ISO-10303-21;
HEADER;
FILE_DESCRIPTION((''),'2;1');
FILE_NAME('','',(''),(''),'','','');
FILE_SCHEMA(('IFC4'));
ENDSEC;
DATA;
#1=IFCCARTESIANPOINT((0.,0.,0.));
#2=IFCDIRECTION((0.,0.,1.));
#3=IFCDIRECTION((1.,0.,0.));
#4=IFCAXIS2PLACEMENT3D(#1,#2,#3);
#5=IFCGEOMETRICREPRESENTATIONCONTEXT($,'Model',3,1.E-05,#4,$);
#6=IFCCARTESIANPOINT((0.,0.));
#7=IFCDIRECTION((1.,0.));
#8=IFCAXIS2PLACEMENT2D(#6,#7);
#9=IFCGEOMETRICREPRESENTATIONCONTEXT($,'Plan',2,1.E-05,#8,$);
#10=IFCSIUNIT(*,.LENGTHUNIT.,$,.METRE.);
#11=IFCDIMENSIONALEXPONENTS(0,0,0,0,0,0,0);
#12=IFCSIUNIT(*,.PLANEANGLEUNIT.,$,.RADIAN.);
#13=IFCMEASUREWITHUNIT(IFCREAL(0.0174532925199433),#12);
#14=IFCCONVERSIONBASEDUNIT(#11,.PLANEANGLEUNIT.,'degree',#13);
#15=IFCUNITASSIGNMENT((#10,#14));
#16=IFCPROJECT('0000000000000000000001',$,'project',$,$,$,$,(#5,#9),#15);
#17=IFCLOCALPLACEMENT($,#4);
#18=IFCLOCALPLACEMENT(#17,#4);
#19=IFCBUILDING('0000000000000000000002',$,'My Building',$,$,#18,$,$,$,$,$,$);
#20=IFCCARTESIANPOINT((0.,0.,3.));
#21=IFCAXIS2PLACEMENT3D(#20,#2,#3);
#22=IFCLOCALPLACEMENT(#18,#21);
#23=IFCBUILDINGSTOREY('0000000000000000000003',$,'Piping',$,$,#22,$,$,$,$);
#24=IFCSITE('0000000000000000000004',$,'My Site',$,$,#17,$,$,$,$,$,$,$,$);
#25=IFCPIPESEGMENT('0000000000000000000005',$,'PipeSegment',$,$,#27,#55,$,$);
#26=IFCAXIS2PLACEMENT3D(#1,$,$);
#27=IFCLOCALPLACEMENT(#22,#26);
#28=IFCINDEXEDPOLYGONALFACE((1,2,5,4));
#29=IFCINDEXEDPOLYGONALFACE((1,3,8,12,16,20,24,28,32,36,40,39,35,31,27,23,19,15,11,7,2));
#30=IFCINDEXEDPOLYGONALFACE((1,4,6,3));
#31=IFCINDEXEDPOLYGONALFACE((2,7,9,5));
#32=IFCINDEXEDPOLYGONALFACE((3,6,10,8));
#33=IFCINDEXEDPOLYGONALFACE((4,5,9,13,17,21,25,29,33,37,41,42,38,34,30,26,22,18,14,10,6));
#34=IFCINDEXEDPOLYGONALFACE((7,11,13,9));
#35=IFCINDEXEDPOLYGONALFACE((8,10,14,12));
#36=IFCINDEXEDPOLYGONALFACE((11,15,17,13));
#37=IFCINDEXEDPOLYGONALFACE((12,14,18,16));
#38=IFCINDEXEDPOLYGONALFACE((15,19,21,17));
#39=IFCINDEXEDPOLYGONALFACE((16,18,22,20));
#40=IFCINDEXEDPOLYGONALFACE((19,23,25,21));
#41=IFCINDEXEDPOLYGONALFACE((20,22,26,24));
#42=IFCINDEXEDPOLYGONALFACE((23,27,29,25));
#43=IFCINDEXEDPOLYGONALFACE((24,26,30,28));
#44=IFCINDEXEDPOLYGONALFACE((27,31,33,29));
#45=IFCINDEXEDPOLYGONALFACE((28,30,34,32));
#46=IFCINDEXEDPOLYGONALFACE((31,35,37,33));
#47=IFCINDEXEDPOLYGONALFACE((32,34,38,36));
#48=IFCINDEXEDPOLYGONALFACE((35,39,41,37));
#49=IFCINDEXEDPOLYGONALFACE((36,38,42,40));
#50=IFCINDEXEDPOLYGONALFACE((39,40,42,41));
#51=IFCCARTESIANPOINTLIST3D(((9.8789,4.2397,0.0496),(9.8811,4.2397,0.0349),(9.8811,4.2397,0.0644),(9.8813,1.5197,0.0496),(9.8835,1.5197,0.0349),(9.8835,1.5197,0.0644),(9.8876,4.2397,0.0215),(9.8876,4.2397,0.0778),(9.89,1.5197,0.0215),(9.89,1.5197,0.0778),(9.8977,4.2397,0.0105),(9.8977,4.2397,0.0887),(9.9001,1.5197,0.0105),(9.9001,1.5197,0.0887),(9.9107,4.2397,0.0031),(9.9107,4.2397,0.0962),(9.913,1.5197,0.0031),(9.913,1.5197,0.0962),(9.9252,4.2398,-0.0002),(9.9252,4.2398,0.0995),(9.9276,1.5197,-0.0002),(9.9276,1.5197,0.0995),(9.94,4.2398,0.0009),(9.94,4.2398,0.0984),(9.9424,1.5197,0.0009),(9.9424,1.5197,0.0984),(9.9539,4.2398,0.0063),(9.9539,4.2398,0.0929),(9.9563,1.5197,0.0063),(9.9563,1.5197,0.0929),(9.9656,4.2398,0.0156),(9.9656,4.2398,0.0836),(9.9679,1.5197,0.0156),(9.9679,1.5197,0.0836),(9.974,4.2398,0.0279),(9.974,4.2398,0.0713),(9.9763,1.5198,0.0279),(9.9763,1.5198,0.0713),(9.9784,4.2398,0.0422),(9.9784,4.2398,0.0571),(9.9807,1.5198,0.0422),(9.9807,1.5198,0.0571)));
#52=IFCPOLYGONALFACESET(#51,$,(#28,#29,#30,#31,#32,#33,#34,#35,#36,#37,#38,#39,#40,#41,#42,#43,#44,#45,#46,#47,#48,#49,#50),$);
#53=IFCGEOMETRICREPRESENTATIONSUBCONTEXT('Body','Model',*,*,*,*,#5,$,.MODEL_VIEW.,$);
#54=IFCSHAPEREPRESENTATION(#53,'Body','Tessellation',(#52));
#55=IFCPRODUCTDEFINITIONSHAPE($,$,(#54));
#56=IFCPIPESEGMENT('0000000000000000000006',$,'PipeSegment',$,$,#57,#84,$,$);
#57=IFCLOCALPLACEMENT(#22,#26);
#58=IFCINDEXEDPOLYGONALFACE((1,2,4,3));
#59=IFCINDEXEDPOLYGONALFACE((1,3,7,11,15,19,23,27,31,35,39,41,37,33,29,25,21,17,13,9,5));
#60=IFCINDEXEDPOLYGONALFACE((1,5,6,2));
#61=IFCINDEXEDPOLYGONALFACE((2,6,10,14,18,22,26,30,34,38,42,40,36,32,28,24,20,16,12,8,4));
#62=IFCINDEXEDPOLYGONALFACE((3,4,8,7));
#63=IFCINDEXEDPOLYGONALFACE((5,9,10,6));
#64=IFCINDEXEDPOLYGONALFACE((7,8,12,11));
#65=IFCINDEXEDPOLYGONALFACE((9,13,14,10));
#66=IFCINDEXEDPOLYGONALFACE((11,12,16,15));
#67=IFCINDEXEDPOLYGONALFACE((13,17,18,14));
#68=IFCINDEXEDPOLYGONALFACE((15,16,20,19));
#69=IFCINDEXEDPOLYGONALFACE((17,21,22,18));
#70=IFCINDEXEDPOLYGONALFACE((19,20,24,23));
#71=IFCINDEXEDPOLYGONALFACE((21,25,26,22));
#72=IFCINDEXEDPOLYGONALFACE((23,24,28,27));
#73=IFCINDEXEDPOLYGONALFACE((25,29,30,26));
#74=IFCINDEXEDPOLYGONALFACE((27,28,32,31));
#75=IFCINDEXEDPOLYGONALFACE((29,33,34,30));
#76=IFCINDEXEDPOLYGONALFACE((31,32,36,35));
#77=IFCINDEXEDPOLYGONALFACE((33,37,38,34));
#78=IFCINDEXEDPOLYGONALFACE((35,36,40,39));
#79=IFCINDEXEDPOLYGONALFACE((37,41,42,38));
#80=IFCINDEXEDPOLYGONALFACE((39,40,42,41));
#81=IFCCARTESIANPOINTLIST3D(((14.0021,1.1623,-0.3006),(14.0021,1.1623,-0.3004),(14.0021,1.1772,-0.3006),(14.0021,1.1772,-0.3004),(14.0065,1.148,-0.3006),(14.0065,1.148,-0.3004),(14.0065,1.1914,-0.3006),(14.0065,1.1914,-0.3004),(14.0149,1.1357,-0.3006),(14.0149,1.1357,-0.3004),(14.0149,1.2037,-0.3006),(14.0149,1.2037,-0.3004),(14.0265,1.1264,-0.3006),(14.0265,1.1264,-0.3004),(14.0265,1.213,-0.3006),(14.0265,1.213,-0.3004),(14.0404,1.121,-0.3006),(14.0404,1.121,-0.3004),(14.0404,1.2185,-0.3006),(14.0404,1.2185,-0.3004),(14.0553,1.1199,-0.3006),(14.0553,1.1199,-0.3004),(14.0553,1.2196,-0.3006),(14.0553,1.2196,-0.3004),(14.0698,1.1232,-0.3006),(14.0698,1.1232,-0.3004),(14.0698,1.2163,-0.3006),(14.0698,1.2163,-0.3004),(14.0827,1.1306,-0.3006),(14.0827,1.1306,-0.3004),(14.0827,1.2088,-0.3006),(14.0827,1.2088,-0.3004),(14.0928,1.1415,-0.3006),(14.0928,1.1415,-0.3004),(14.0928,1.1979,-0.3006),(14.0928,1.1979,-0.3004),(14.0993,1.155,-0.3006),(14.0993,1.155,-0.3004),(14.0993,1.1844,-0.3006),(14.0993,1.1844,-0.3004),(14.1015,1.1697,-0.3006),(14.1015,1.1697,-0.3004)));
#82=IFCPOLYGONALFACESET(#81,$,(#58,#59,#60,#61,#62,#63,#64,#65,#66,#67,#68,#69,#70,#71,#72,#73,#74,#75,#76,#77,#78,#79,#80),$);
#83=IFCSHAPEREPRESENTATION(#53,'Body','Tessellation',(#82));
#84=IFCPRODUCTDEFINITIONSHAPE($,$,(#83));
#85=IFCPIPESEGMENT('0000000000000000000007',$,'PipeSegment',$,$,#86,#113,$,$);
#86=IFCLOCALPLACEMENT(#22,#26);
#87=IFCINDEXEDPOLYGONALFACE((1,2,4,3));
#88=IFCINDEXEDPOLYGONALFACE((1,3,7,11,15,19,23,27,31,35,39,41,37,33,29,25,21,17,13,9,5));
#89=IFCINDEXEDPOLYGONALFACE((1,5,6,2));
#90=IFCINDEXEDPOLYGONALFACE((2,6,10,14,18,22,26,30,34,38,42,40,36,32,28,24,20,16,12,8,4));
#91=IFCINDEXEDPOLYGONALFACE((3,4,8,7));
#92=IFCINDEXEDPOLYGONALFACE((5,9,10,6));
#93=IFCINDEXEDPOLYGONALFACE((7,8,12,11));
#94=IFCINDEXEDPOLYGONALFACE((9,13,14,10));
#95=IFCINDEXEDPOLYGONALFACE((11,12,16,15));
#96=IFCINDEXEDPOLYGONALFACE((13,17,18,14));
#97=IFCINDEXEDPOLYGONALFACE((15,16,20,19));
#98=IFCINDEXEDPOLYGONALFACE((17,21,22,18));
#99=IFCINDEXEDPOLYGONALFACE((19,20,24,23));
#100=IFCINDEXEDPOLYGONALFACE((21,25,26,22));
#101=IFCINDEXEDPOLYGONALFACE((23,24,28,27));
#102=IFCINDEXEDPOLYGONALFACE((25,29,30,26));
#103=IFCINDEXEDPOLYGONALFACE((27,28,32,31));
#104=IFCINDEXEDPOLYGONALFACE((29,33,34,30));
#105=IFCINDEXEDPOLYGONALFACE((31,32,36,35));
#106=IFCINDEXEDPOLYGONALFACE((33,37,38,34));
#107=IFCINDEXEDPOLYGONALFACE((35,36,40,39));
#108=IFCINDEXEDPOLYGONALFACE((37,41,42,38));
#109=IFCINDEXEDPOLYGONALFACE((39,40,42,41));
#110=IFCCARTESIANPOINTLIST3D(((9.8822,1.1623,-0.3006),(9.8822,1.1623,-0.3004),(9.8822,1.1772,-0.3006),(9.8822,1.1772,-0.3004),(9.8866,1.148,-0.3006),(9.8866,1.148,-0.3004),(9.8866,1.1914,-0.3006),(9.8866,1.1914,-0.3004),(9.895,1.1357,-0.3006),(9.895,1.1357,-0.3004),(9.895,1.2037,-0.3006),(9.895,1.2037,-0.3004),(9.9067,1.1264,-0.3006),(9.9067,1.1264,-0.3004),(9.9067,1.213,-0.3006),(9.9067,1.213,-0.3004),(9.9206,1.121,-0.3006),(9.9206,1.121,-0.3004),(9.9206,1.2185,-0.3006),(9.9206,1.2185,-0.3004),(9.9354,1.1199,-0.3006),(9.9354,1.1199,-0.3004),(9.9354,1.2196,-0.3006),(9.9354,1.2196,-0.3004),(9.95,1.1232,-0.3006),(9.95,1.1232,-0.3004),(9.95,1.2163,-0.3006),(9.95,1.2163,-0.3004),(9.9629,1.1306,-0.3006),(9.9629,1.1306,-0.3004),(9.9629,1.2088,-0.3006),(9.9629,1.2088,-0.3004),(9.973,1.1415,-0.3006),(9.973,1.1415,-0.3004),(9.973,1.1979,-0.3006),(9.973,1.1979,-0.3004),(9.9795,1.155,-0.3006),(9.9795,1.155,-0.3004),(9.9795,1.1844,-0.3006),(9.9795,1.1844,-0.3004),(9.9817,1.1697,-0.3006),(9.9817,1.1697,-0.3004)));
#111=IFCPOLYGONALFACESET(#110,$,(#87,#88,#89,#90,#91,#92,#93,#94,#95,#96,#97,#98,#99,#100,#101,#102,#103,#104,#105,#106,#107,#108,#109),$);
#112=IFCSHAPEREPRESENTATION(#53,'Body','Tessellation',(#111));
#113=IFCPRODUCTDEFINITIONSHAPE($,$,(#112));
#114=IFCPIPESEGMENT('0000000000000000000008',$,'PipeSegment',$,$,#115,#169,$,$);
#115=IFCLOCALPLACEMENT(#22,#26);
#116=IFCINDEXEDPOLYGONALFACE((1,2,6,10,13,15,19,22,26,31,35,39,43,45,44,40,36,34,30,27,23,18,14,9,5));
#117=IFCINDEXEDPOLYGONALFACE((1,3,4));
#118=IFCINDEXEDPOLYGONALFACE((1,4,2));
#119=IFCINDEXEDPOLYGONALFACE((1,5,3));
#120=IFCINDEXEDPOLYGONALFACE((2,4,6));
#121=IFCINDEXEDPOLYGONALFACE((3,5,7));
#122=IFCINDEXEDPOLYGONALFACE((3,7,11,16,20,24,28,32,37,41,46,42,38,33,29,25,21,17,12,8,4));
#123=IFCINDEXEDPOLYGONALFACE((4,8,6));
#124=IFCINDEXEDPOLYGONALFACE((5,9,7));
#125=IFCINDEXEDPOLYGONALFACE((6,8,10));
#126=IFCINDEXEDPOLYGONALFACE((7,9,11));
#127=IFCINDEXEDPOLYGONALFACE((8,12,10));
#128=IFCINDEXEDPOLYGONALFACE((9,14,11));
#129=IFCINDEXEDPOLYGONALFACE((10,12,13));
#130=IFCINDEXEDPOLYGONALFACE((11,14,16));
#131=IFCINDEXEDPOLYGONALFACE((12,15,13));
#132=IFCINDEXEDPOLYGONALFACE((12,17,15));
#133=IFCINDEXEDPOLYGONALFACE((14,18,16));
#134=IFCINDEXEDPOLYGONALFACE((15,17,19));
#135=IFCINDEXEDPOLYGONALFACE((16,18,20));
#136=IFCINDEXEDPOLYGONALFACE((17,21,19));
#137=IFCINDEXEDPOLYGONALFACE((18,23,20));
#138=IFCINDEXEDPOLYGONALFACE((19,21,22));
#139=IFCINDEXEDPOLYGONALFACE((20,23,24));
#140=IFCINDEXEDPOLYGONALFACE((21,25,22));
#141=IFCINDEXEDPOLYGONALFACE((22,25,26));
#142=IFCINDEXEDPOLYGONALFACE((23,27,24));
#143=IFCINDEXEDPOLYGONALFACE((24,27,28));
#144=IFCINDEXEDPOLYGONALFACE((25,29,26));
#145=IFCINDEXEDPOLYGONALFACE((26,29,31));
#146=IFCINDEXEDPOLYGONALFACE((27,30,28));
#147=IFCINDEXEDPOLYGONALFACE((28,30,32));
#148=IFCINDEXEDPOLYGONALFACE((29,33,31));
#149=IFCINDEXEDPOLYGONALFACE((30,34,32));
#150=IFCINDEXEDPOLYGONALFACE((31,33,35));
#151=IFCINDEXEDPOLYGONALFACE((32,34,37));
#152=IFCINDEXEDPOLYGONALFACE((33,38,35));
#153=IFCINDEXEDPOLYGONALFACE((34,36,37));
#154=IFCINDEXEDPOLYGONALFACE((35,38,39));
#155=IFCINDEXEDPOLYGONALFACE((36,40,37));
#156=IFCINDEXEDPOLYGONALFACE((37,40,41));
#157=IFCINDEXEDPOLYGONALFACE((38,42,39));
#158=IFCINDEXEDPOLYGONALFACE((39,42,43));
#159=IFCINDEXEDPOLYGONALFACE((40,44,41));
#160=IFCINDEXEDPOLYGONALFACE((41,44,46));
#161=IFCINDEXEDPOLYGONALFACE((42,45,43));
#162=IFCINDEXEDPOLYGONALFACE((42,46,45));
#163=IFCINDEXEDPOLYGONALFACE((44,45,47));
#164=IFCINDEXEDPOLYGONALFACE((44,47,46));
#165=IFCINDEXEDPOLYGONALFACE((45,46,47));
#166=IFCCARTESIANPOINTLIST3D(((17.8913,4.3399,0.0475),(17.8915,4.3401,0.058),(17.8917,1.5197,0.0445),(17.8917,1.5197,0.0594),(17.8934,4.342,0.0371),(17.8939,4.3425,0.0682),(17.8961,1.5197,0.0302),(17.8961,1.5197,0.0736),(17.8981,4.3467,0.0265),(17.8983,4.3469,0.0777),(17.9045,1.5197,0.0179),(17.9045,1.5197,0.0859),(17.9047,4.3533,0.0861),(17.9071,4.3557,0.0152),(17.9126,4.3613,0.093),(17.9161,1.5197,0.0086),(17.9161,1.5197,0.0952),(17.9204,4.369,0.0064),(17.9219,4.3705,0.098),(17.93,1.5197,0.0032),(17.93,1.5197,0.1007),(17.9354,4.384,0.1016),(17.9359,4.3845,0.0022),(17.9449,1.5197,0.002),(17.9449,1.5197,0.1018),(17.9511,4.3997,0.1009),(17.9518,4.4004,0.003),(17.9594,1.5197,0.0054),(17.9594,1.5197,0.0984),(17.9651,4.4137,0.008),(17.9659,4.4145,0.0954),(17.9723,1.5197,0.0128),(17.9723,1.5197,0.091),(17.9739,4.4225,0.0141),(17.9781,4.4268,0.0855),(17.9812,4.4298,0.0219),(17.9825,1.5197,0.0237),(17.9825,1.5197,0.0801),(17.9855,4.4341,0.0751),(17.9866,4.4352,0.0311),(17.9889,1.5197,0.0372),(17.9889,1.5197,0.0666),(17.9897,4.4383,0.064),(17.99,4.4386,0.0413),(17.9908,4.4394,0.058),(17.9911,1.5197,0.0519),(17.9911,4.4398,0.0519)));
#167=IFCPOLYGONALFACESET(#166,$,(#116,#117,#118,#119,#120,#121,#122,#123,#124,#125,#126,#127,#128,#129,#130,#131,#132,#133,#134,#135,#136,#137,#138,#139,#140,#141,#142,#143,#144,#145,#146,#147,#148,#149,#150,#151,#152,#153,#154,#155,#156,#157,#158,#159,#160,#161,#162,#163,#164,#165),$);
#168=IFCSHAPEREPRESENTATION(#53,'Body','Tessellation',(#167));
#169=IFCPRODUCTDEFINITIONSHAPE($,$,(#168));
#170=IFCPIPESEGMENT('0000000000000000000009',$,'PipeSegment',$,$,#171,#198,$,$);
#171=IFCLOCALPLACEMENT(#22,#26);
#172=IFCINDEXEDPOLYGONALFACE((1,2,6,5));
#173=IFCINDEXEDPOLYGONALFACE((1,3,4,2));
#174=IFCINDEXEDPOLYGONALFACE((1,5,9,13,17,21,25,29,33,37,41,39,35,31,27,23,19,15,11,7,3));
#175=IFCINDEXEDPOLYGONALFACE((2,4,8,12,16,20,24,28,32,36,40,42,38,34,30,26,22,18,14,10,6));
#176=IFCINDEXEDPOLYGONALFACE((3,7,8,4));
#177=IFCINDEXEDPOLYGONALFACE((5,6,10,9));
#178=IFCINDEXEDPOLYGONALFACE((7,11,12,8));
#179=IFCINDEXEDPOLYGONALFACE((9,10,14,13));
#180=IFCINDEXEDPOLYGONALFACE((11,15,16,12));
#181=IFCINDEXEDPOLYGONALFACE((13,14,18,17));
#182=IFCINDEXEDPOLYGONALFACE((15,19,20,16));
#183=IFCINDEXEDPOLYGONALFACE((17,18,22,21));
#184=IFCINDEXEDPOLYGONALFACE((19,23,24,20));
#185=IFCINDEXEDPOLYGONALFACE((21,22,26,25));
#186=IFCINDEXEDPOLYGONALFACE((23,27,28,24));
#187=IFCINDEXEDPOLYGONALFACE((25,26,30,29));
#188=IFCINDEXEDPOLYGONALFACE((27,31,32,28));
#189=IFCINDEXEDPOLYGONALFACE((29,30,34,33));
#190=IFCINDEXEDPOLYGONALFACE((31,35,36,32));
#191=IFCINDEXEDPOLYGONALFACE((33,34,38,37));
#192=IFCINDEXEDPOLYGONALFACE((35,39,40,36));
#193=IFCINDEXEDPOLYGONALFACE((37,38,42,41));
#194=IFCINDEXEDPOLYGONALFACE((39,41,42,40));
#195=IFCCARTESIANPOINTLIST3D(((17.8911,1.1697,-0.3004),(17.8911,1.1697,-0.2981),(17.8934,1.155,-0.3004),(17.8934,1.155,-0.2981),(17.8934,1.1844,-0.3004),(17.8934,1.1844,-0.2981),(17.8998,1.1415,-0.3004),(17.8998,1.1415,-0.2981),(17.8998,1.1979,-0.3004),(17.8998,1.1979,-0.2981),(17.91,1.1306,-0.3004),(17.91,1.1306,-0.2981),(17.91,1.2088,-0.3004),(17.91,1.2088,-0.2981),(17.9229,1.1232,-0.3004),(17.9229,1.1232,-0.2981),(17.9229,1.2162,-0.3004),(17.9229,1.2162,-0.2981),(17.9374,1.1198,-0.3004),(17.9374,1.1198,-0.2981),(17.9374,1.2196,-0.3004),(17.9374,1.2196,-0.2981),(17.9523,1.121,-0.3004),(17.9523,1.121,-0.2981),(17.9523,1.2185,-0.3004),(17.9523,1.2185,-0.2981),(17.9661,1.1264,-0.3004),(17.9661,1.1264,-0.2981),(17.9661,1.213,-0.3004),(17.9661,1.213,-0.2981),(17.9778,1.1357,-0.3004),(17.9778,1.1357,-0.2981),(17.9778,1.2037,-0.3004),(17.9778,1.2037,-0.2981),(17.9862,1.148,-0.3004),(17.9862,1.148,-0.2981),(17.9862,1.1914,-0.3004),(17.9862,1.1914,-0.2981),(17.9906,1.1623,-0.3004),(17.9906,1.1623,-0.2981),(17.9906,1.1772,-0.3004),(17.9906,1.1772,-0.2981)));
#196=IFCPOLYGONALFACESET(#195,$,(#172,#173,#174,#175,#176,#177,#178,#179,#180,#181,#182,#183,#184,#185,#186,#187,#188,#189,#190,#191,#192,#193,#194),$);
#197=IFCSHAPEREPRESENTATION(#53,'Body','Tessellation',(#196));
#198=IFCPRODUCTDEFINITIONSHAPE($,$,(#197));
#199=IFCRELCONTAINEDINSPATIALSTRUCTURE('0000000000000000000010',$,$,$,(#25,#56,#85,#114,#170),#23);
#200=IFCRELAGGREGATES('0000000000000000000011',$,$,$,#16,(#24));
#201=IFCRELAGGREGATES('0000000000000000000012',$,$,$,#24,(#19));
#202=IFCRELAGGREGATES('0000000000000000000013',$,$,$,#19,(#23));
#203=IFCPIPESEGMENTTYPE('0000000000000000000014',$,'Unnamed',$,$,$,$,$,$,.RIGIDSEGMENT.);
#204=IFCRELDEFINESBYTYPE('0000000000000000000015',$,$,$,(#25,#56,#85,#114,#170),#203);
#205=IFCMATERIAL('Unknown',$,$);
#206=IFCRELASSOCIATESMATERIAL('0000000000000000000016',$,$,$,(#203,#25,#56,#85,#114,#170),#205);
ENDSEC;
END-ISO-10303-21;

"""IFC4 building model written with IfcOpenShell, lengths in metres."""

from ifc_helpers import new_model, entity, si_unit, converted_unit, frame, origin_with_axes, origin_2d_with_axis, place, context, subcontext, project, spatial, circle, extrude, clip, halfspace, material, material_profile, profile_set, profile_usage, type_object, element, save


model = new_model("IFC4")

# Units and contexts
model_context = context("Model", 3, precision=1e-05, world=origin_with_axes())
plan_context = context("Plan", 2, precision=1e-05, world=origin_2d_with_axis())
body_context = subcontext(model_context, "Body", "Model", "MODEL_VIEW")
ifc_project = project(units=[si_unit("LENGTHUNIT", "METRE"), converted_unit("PLANEANGLEUNIT", "degree", entity("IfcReal", 0.0174532925199433), si_unit("PLANEANGLEUNIT", "RADIAN"), dimensions=[0, 0, 0, 0, 0, 0, 0])], contexts=[model_context, plan_context])

# Site, building, storey
site_placement = place(None, origin_with_axes())
site = spatial("IfcSite", under=ifc_project, at=site_placement, Name="My Site")
building_placement = place(site_placement, origin_with_axes())
building = spatial("IfcBuilding", under=site, at=building_placement, Name="My Building")
storey_placement = place(building_placement, frame((0.0, 0.0, 3.0), z_axis=(0.0, 0.0, 1.0), x_axis=(1.0, 0.0, 0.0)))
storey = spatial("IfcBuildingStorey", under=building, at=storey_placement, Name="Piping")

# Pipe segments
ifc_material = material(Name="Unknown")
ifc_material_profile_1 = material_profile(ifc_material, circle(Radius=0.05))
ifc_profile_set_1 = profile_set([ifc_material_profile_1])
pipe_segment_type = type_object("IfcPipeSegmentType", Name="Unnamed", PredefinedType="RIGIDSEGMENT", material=ifc_profile_set_1)
ifc_profile_usage_1 = profile_usage(ifc_profile_set_1, cardinal=5)
pipe_segment_1_placement = place(storey_placement, frame((9.9313, 1.5197, 0.0496), z_axis=(-0.000873, 1.0, 0.000001), x_axis=(-1.0, -0.000873, 0.0)))
element("IfcPipeSegment", 1, at=pipe_segment_1_placement, inside=storey, type_object=pipe_segment_type, material=ifc_profile_usage_1, Name="PipeSegment", context=body_context, shape_type="SweptSolid", body=[
    extrude(circle(Radius=0.05), origin_with_axes(), (0.0, 0.0, 1.0), 2.7201),
])
ifc_profile_usage_2 = profile_usage(ifc_profile_set_1, cardinal=16)
pipe_segment_2_placement = place(storey_placement, frame((14.0515, 1.1697, -0.3004), z_axis=(0.0, 0.0, -1.0), x_axis=(1.0, 0.0, 0.0)))
element("IfcPipeSegment", 2, at=pipe_segment_2_placement, inside=storey, type_object=pipe_segment_type, material=ifc_profile_usage_2, Name="PipeSegment", context=body_context, shape_type="SweptSolid", body=[
    extrude(circle(Radius=0.05), origin_with_axes(), (0.0, 0.0, 1.0), 0.0002),
])
ifc_profile_usage_3 = profile_usage(ifc_profile_set_1, cardinal=16)
pipe_segment_3_placement = place(storey_placement, frame((9.9317, 1.1697, -0.3004), z_axis=(0.0, 0.0, -1.0), x_axis=(1.0, 0.0, 0.0)))
element("IfcPipeSegment", 3, at=pipe_segment_3_placement, inside=storey, type_object=pipe_segment_type, material=ifc_profile_usage_3, Name="PipeSegment", context=body_context, shape_type="SweptSolid", body=[
    extrude(circle(Radius=0.05), origin_with_axes(), (0.0, 0.0, 1.0), 0.0002),
])
ifc_profile_usage_4 = profile_usage(ifc_profile_set_1, cardinal=5)
pipe_segment_4_placement = place(storey_placement, frame((17.9411, 4.4398, 0.0519), z_axis=(0.0, -1.0, 0.000005), x_axis=(1.0, 0.0, 0.0)))
element("IfcPipeSegment", 4, at=pipe_segment_4_placement, inside=storey, type_object=pipe_segment_type, material=ifc_profile_usage_4, Name="PipeSegment", context=body_context, shape_type="Clipping", body=[
    clip(extrude(circle(Radius=0.05), origin_with_axes(), (0.0, 0.0, 1.0), 2.92), halfspace(frame((0.05, -3.0519, 0.0), z_axis=(-0.707114, 0.000004, -0.7071), x_axis=(0.000005, 1.0, 0.0)), False)),
])
ifc_profile_usage_5 = profile_usage(ifc_profile_set_1, cardinal=5)
pipe_segment_5_placement = place(storey_placement, frame((17.9411, 1.1697, -0.2981), z_axis=(0.0, 0.0, -1.0), x_axis=(-1.0, 0.0, 0.0)))
element("IfcPipeSegment", 5, at=pipe_segment_5_placement, inside=storey, type_object=pipe_segment_type, material=ifc_profile_usage_5, Name="PipeSegment", context=body_context, shape_type="SweptSolid", body=[
    extrude(circle(Radius=0.05), origin_with_axes(), (0.0, 0.0, 1.0), 0.0023),
])

save(model, "model.ifc")
